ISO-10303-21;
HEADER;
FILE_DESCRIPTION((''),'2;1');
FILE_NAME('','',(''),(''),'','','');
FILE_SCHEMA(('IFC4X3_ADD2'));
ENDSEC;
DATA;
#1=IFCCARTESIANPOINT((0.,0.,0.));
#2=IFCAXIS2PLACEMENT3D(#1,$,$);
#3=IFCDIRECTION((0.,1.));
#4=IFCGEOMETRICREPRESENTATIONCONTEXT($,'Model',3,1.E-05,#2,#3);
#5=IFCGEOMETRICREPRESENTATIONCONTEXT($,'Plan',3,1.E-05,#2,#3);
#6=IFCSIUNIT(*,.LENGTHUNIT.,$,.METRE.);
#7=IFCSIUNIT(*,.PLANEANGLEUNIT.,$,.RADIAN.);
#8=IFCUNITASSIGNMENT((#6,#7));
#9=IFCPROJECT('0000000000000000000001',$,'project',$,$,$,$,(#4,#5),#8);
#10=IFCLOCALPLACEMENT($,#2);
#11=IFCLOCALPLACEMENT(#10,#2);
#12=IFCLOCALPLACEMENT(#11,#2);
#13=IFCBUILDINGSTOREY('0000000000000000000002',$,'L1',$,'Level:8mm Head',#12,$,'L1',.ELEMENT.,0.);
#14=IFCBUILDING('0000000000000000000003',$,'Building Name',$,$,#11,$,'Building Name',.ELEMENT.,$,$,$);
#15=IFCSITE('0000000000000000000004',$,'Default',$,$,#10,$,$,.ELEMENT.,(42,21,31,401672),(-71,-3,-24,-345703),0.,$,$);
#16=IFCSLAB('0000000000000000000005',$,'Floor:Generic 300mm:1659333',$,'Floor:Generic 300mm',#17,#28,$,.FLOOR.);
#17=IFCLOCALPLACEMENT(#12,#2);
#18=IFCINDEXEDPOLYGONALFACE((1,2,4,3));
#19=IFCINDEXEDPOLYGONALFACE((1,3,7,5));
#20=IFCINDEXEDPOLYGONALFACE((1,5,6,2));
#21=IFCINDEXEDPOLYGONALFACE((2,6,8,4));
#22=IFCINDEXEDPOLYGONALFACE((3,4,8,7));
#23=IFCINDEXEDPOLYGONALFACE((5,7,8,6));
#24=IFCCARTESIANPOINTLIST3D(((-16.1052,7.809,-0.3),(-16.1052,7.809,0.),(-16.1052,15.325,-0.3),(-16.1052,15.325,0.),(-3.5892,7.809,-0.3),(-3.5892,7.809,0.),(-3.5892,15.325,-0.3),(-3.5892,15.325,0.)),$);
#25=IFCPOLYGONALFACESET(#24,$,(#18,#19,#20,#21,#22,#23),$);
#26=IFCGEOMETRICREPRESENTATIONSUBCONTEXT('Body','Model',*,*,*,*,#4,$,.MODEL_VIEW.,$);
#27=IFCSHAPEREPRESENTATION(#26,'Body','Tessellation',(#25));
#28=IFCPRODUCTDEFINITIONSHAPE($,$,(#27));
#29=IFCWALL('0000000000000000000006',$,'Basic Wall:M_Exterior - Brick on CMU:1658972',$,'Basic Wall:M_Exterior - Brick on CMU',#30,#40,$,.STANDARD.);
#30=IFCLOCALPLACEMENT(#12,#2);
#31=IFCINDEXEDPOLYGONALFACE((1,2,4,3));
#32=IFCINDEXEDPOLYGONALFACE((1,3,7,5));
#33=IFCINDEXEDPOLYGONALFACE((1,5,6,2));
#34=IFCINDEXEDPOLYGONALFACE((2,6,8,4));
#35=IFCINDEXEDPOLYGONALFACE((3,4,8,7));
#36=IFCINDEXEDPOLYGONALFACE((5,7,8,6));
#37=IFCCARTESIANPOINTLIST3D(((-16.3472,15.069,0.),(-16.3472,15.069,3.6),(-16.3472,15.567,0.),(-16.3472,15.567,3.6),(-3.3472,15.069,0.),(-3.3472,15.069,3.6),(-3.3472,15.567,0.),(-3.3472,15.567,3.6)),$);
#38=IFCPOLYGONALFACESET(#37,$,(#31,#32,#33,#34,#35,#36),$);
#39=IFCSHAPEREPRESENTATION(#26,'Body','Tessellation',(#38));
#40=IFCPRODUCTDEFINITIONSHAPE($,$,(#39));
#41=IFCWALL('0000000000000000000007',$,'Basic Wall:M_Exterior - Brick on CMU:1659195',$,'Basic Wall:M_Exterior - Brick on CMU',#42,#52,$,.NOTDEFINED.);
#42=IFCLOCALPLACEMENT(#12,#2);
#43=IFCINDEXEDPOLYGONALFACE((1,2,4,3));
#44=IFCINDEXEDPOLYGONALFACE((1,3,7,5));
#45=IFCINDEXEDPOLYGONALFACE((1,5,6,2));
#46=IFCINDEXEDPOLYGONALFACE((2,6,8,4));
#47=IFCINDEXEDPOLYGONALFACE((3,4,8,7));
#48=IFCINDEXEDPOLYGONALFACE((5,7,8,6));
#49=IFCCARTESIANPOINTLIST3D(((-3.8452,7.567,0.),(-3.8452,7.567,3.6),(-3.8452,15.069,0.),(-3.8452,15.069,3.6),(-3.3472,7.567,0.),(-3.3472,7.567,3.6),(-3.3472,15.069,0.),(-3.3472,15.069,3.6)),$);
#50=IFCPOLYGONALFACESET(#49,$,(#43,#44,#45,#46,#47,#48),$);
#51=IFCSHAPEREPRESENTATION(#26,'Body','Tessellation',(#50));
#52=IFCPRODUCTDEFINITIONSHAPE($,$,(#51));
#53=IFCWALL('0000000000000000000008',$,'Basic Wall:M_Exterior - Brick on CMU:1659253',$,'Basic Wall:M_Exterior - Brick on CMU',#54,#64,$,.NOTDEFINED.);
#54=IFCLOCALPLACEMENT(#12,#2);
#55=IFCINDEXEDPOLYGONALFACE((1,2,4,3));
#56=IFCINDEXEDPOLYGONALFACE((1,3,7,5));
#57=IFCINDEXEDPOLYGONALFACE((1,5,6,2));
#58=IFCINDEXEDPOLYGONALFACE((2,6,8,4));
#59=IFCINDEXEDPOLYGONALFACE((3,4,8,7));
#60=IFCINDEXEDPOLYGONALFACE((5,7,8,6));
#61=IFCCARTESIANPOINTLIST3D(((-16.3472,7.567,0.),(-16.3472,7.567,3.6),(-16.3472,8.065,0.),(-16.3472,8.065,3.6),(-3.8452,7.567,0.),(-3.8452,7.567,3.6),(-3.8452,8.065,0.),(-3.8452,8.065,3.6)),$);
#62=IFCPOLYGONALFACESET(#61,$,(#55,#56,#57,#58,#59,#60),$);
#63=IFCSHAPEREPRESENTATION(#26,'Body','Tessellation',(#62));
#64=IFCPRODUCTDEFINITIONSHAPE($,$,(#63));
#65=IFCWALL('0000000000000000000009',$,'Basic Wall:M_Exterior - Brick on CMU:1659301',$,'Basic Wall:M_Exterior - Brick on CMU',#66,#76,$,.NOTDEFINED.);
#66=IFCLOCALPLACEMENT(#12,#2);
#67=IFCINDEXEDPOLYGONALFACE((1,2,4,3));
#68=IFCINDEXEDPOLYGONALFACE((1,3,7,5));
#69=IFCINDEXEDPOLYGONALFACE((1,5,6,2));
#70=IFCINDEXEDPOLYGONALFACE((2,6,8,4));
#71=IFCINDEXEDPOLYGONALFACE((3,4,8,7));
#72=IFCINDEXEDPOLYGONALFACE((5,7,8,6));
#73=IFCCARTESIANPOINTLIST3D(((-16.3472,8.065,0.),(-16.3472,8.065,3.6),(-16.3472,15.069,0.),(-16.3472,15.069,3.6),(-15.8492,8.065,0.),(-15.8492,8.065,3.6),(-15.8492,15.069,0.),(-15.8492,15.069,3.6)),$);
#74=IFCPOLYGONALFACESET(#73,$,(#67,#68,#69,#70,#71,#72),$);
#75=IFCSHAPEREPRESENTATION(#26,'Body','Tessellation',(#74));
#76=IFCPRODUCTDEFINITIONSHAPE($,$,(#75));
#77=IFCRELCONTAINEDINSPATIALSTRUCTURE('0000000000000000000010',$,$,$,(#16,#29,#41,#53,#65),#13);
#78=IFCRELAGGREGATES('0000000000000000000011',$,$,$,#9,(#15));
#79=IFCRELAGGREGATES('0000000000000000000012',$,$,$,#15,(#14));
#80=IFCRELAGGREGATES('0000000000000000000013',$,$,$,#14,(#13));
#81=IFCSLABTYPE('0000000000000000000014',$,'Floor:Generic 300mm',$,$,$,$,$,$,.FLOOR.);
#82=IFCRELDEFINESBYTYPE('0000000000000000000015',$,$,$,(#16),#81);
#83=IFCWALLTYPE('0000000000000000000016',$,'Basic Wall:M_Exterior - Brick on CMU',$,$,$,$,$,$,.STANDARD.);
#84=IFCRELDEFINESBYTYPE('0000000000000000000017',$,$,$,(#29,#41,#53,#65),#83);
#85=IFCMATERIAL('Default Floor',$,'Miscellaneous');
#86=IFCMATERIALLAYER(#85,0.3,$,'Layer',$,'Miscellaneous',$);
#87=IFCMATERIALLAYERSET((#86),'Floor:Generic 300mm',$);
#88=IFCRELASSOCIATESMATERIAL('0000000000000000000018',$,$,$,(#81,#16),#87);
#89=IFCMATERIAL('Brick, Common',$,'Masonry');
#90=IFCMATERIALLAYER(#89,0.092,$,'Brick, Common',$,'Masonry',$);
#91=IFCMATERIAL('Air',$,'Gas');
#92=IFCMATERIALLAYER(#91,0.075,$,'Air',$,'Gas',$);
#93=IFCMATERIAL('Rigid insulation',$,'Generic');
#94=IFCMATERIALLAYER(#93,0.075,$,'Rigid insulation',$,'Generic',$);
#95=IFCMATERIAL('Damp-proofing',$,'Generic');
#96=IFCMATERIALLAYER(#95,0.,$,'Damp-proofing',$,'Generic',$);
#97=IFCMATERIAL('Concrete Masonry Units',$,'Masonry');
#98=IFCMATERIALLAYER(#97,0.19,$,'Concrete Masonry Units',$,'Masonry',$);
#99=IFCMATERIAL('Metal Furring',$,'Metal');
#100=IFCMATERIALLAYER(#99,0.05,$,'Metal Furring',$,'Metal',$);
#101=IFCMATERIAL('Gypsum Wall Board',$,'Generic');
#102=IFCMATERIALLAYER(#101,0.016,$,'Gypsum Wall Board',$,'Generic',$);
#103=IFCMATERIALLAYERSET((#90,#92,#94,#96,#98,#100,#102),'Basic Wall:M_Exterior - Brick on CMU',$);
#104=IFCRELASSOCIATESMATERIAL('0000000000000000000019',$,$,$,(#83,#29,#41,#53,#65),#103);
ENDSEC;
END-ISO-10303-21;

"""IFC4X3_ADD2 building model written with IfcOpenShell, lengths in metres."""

from ifc_helpers import new_model, si_unit, direction, frame, frame_2d, origin, place, context, subcontext, project, spatial, rectangle, extrude, material, layer, layer_set, layer_usage, type_object, element, save


model = new_model("IFC4X3_ADD2")

# Units and contexts
model_context = context("Model", 3, precision=1e-05, world=origin(), true_north=direction((0.0, 1.0)))
plan_context = context("Plan", 3, precision=1e-05, world=origin(), true_north=direction((0.0, 1.0)))
body_context = subcontext(model_context, "Body", "Model", "MODEL_VIEW")
ifc_project = project(units=[si_unit("LENGTHUNIT", "METRE"), si_unit("PLANEANGLEUNIT", "RADIAN")], contexts=[model_context, plan_context])

# Site, building, storey
site_placement = place(None, origin())
site = spatial("IfcSite", under=ifc_project, at=site_placement, Name="Default", CompositionType="ELEMENT", RefLatitude=(42, 21, 31, 401672), RefLongitude=(-71, -3, -24, -345703), RefElevation=0.0)
building_placement = place(site_placement, origin())
building = spatial("IfcBuilding", under=site, at=building_placement, Name="Building Name", LongName="Building Name", CompositionType="ELEMENT")
storey_placement = place(building_placement, origin())
storey = spatial("IfcBuildingStorey", under=building, at=storey_placement, Name="L1", ObjectType="Level:8mm Head", LongName="L1", CompositionType="ELEMENT", Elevation=0.0)

# Slab
ifc_material_1 = material(Name="Default Floor", Category="Miscellaneous")
ifc_layer_1 = layer(ifc_material_1, 0.3, Name="Layer", Category="Miscellaneous")
ifc_layer_set_1 = layer_set([ifc_layer_1], Name="Floor:Generic 300mm")
ifc_layer_usage = layer_usage(ifc_layer_set_1, "AXIS3", "POSITIVE", 0.0)
slab_type = type_object("IfcSlabType", Name="Floor:Generic 300mm", PredefinedType="FLOOR", material=ifc_layer_set_1)
slab_placement = place(storey_placement, origin())
element("IfcSlab", 1, at=slab_placement, inside=storey, type_object=slab_type, material=ifc_layer_usage, Name="Floor:Generic 300mm:1659333", ObjectType="Floor:Generic 300mm", PredefinedType="FLOOR", context=body_context, shape_type="SweptSolid", body=[
    extrude(rectangle(XDim=7.516, YDim=12.516, at=frame_2d((0.0, 0.0), x_axis=(1.0, 0.0))), frame((-9.8472, 11.567, 0.0), z_axis=(0.0, 0.0, -1.0), x_axis=(0.0, 1.0, 0.0)), (0.0, 0.0, 1.0), 0.3),
])

# Walls
ifc_material_2 = material(Name="Brick, Common", Category="Masonry")
ifc_layer_2 = layer(ifc_material_2, 0.092, Name="Brick, Common", Category="Masonry")
ifc_material_3 = material(Name="Air", Category="Gas")
ifc_layer_3 = layer(ifc_material_3, 0.075, Name="Air", Category="Gas")
ifc_material_4 = material(Name="Rigid insulation", Category="Generic")
ifc_layer_4 = layer(ifc_material_4, 0.075, Name="Rigid insulation", Category="Generic")
ifc_material_5 = material(Name="Damp-proofing", Category="Generic")
ifc_layer_5 = layer(ifc_material_5, 0.0, Name="Damp-proofing", Category="Generic")
ifc_material_6 = material(Name="Concrete Masonry Units", Category="Masonry")
ifc_layer_6 = layer(ifc_material_6, 0.19, Name="Concrete Masonry Units", Category="Masonry")
ifc_material_7 = material(Name="Metal Furring", Category="Metal")
ifc_layer_7 = layer(ifc_material_7, 0.05, Name="Metal Furring", Category="Metal")
ifc_material_8 = material(Name="Gypsum Wall Board", Category="Generic")
ifc_layer_8 = layer(ifc_material_8, 0.016, Name="Gypsum Wall Board", Category="Generic")
ifc_layer_set_2 = layer_set([ifc_layer_2, ifc_layer_3, ifc_layer_4, ifc_layer_5, ifc_layer_6, ifc_layer_7, ifc_layer_8], Name="Basic Wall:M_Exterior - Brick on CMU")
wall_type = type_object("IfcWallType", Name="Basic Wall:M_Exterior - Brick on CMU", PredefinedType="STANDARD", material=ifc_layer_set_2)
wall_1_placement = place(storey_placement, frame((-16.3472, 15.318, 0.0)))
element("IfcWall", 2, at=wall_1_placement, inside=storey, type_object=wall_type, material=ifc_layer_set_2, Name="Basic Wall:M_Exterior - Brick on CMU:1658972", ObjectType="Basic Wall:M_Exterior - Brick on CMU", PredefinedType="STANDARD", context=body_context, shape_type="SweptSolid", body=[
    extrude(rectangle(XDim=13.0, YDim=0.498, at=frame_2d((6.5, 0.0), x_axis=(-1.0, 0.0))), origin(), (0.0, 0.0, 1.0), 3.6),
])
wall_2_placement = place(storey_placement, frame((-3.5962, 15.069, 0.0), z_axis=(0.0, 0.0, 1.0), x_axis=(0.0, -1.0, 0.0)))
element("IfcWall", 3, at=wall_2_placement, inside=storey, type_object=wall_type, material=ifc_layer_set_2, Name="Basic Wall:M_Exterior - Brick on CMU:1659195", ObjectType="Basic Wall:M_Exterior - Brick on CMU", PredefinedType="NOTDEFINED", context=body_context, shape_type="SweptSolid", body=[
    extrude(rectangle(XDim=7.502, YDim=0.498, at=frame_2d((3.751, 0.0), x_axis=(-1.0, 0.0))), origin(), (0.0, 0.0, 1.0), 3.6),
])
wall_3_placement = place(storey_placement, frame((-3.8452, 7.816, 0.0), z_axis=(0.0, 0.0, 1.0), x_axis=(-1.0, 0.0, 0.0)))
element("IfcWall", 4, at=wall_3_placement, inside=storey, type_object=wall_type, material=ifc_layer_set_2, Name="Basic Wall:M_Exterior - Brick on CMU:1659253", ObjectType="Basic Wall:M_Exterior - Brick on CMU", PredefinedType="NOTDEFINED", context=body_context, shape_type="SweptSolid", body=[
    extrude(rectangle(XDim=12.502, YDim=0.498, at=frame_2d((6.251, 0.0), x_axis=(-1.0, 0.0))), origin(), (0.0, 0.0, 1.0), 3.6),
])
wall_4_placement = place(storey_placement, frame((-16.0982, 8.065, 0.0), z_axis=(0.0, 0.0, 1.0), x_axis=(0.0, 1.0, 0.0)))
element("IfcWall", 5, at=wall_4_placement, inside=storey, type_object=wall_type, material=ifc_layer_set_2, Name="Basic Wall:M_Exterior - Brick on CMU:1659301", ObjectType="Basic Wall:M_Exterior - Brick on CMU", PredefinedType="NOTDEFINED", context=body_context, shape_type="SweptSolid", body=[
    extrude(rectangle(XDim=7.004, YDim=0.498, at=frame_2d((3.502, 0.0), x_axis=(-1.0, 0.0))), origin(), (0.0, 0.0, 1.0), 3.6),
])

save(model, "model.ifc")
